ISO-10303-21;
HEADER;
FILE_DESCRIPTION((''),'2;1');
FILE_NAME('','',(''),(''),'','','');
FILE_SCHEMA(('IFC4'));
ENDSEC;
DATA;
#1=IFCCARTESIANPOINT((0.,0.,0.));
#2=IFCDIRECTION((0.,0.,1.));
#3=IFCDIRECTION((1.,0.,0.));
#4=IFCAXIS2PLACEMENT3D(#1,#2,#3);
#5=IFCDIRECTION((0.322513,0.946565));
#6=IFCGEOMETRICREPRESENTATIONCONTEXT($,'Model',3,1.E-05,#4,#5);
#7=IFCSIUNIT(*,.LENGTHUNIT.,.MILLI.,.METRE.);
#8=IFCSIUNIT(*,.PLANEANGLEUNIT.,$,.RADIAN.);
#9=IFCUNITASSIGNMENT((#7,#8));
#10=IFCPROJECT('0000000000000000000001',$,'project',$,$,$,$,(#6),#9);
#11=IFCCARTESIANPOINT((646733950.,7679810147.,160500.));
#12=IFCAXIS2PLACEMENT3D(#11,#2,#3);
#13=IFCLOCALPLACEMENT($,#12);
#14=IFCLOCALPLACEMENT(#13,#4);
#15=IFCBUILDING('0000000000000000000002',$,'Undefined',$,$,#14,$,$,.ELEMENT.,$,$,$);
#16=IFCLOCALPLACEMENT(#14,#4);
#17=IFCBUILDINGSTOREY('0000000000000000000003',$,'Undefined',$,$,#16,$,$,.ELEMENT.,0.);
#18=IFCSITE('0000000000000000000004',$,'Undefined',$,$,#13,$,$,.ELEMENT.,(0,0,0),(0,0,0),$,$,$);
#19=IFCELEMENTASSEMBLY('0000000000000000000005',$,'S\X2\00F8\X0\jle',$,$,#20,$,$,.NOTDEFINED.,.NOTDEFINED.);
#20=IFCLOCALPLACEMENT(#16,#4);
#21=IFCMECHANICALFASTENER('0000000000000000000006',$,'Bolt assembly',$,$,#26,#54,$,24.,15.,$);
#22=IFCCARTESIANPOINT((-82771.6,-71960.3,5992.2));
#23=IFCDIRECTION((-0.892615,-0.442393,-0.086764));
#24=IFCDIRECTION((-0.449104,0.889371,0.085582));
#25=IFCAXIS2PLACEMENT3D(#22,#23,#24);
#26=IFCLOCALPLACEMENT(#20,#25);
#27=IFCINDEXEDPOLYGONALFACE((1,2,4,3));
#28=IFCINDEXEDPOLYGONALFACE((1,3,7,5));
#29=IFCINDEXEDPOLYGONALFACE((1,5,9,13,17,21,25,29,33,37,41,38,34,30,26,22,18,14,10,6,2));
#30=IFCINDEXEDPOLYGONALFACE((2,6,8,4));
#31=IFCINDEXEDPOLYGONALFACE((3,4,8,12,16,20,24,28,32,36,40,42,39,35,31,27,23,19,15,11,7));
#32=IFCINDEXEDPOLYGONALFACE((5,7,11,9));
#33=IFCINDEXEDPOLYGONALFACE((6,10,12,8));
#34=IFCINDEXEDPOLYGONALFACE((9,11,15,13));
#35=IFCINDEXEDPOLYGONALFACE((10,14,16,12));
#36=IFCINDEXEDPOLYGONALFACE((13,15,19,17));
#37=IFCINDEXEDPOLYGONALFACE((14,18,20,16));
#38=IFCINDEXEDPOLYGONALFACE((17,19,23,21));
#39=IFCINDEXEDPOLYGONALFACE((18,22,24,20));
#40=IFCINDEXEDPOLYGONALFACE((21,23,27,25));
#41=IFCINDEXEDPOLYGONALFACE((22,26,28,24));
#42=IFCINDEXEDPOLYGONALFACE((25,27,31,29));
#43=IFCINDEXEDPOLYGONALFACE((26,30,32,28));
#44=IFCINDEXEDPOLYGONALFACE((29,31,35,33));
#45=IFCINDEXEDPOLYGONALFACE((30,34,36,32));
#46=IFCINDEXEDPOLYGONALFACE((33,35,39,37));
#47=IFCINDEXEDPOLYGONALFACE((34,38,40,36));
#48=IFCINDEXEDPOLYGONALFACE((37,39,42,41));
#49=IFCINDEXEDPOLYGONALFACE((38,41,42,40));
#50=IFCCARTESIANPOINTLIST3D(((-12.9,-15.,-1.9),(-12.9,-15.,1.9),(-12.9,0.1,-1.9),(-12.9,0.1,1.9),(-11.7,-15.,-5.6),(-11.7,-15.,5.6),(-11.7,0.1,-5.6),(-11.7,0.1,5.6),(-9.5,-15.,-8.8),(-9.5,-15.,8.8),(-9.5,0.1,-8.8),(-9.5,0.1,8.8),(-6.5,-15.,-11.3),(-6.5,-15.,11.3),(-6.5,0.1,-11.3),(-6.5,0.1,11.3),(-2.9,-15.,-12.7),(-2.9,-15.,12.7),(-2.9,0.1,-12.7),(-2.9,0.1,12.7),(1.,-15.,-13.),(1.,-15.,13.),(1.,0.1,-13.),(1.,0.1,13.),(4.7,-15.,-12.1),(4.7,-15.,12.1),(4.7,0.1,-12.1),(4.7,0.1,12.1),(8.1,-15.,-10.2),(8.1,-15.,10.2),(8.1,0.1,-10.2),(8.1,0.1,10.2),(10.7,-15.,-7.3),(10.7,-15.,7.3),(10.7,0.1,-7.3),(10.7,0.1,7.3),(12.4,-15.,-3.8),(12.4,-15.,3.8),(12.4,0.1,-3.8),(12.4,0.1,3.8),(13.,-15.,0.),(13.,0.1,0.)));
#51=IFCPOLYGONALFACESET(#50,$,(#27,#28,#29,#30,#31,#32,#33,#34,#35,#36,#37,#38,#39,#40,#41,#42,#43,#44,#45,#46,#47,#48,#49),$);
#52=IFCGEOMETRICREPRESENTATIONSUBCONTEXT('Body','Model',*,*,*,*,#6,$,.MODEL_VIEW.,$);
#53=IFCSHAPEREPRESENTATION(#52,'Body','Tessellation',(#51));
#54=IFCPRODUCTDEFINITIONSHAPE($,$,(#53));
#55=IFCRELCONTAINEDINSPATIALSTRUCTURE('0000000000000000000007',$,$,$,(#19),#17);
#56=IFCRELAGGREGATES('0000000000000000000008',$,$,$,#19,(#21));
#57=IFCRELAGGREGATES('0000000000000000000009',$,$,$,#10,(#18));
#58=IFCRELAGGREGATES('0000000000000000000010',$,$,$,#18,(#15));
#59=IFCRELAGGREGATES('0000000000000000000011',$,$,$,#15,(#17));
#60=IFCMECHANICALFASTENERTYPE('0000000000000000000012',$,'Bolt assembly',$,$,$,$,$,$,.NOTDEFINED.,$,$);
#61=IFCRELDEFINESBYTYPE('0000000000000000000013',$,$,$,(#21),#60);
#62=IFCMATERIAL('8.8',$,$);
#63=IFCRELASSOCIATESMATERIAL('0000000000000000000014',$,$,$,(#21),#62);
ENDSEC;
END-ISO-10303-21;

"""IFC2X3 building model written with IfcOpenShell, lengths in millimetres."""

from ifc_helpers import new_model, si_unit, direction, frame, origin_with_axes, origin_2d_with_axis, place, context, subcontext, project, spatial, circle, extrude, source, transform, mapped, material, type_object, element, aggregate, save


model = new_model("IFC2X3")

# Units and contexts
model_context = context("Model", 3, precision=1e-05, world=origin_with_axes(), true_north=direction((0.322513, 0.946565)))
body_context = subcontext(model_context, "Body", "Model", "MODEL_VIEW")
ifc_project = project(units=[si_unit("LENGTHUNIT", "METRE", prefix="MILLI"), si_unit("PLANEANGLEUNIT", "RADIAN")], contexts=[model_context])

# Site, building, storey
site_placement = place(None, frame((646733950.0, 7679810147.0, 160500.0), z_axis=(0.0, 0.0, 1.0), x_axis=(1.0, 0.0, 0.0)))
site = spatial("IfcSite", under=ifc_project, at=site_placement, Name="Undefined", CompositionType="ELEMENT", RefLatitude=(0, 0, 0), RefLongitude=(0, 0, 0))
building_placement = place(site_placement, origin_with_axes())
building = spatial("IfcBuilding", under=site, at=building_placement, Name="Undefined", CompositionType="ELEMENT")
storey_placement = place(building_placement, origin_with_axes())
storey = spatial("IfcBuildingStorey", under=building, at=storey_placement, Name="Undefined", CompositionType="ELEMENT", Elevation=0.0)

# Element assembly
assembly_1_placement = place(storey_placement, origin_with_axes())
assembly_1 = element("IfcElementAssembly", 1, at=assembly_1_placement, inside=storey, Name="Søjle", AssemblyPlace="NOTDEFINED", PredefinedType="NOTDEFINED")
ifc_material_1 = material(Name="8.8")
mechanical_fastener_type = type_object("IfcMechanicalFastenerType", Name="Bolt assembly")

# Mechanical fastener
shared_shape_1 = source(origin_with_axes(), body_context, "Body", "SweptSolid", [
    extrude(circle(Radius=13.0, at=origin_2d_with_axis()), frame((0.0, -15.0, 0.0), z_axis=(0.0, 1.0, 0.0), x_axis=(1.0, 0.0, 0.0)), (0.0, 0.0, 1.0), 15.1),
])
mechanical_fastener_1_placement = place(assembly_1_placement, frame((-82771.6, -71960.3, 5992.2), z_axis=(-0.892615, -0.442393, -0.086764), x_axis=(-0.449104, 0.889371, 0.085582)))
mechanical_fastener_1 = element("IfcMechanicalFastener", 2, at=mechanical_fastener_1_placement, type_object=mechanical_fastener_type, material=ifc_material_1, Name="Bolt assembly", NominalDiameter=24.0, NominalLength=15.0, context=body_context, shape_type="MappedRepresentation", body=[
    mapped(shared_shape_1, transform((0.0, 0.0, 0.0))),
])
aggregate(assembly_1, [mechanical_fastener_1])

save(model, "model.ifc")
